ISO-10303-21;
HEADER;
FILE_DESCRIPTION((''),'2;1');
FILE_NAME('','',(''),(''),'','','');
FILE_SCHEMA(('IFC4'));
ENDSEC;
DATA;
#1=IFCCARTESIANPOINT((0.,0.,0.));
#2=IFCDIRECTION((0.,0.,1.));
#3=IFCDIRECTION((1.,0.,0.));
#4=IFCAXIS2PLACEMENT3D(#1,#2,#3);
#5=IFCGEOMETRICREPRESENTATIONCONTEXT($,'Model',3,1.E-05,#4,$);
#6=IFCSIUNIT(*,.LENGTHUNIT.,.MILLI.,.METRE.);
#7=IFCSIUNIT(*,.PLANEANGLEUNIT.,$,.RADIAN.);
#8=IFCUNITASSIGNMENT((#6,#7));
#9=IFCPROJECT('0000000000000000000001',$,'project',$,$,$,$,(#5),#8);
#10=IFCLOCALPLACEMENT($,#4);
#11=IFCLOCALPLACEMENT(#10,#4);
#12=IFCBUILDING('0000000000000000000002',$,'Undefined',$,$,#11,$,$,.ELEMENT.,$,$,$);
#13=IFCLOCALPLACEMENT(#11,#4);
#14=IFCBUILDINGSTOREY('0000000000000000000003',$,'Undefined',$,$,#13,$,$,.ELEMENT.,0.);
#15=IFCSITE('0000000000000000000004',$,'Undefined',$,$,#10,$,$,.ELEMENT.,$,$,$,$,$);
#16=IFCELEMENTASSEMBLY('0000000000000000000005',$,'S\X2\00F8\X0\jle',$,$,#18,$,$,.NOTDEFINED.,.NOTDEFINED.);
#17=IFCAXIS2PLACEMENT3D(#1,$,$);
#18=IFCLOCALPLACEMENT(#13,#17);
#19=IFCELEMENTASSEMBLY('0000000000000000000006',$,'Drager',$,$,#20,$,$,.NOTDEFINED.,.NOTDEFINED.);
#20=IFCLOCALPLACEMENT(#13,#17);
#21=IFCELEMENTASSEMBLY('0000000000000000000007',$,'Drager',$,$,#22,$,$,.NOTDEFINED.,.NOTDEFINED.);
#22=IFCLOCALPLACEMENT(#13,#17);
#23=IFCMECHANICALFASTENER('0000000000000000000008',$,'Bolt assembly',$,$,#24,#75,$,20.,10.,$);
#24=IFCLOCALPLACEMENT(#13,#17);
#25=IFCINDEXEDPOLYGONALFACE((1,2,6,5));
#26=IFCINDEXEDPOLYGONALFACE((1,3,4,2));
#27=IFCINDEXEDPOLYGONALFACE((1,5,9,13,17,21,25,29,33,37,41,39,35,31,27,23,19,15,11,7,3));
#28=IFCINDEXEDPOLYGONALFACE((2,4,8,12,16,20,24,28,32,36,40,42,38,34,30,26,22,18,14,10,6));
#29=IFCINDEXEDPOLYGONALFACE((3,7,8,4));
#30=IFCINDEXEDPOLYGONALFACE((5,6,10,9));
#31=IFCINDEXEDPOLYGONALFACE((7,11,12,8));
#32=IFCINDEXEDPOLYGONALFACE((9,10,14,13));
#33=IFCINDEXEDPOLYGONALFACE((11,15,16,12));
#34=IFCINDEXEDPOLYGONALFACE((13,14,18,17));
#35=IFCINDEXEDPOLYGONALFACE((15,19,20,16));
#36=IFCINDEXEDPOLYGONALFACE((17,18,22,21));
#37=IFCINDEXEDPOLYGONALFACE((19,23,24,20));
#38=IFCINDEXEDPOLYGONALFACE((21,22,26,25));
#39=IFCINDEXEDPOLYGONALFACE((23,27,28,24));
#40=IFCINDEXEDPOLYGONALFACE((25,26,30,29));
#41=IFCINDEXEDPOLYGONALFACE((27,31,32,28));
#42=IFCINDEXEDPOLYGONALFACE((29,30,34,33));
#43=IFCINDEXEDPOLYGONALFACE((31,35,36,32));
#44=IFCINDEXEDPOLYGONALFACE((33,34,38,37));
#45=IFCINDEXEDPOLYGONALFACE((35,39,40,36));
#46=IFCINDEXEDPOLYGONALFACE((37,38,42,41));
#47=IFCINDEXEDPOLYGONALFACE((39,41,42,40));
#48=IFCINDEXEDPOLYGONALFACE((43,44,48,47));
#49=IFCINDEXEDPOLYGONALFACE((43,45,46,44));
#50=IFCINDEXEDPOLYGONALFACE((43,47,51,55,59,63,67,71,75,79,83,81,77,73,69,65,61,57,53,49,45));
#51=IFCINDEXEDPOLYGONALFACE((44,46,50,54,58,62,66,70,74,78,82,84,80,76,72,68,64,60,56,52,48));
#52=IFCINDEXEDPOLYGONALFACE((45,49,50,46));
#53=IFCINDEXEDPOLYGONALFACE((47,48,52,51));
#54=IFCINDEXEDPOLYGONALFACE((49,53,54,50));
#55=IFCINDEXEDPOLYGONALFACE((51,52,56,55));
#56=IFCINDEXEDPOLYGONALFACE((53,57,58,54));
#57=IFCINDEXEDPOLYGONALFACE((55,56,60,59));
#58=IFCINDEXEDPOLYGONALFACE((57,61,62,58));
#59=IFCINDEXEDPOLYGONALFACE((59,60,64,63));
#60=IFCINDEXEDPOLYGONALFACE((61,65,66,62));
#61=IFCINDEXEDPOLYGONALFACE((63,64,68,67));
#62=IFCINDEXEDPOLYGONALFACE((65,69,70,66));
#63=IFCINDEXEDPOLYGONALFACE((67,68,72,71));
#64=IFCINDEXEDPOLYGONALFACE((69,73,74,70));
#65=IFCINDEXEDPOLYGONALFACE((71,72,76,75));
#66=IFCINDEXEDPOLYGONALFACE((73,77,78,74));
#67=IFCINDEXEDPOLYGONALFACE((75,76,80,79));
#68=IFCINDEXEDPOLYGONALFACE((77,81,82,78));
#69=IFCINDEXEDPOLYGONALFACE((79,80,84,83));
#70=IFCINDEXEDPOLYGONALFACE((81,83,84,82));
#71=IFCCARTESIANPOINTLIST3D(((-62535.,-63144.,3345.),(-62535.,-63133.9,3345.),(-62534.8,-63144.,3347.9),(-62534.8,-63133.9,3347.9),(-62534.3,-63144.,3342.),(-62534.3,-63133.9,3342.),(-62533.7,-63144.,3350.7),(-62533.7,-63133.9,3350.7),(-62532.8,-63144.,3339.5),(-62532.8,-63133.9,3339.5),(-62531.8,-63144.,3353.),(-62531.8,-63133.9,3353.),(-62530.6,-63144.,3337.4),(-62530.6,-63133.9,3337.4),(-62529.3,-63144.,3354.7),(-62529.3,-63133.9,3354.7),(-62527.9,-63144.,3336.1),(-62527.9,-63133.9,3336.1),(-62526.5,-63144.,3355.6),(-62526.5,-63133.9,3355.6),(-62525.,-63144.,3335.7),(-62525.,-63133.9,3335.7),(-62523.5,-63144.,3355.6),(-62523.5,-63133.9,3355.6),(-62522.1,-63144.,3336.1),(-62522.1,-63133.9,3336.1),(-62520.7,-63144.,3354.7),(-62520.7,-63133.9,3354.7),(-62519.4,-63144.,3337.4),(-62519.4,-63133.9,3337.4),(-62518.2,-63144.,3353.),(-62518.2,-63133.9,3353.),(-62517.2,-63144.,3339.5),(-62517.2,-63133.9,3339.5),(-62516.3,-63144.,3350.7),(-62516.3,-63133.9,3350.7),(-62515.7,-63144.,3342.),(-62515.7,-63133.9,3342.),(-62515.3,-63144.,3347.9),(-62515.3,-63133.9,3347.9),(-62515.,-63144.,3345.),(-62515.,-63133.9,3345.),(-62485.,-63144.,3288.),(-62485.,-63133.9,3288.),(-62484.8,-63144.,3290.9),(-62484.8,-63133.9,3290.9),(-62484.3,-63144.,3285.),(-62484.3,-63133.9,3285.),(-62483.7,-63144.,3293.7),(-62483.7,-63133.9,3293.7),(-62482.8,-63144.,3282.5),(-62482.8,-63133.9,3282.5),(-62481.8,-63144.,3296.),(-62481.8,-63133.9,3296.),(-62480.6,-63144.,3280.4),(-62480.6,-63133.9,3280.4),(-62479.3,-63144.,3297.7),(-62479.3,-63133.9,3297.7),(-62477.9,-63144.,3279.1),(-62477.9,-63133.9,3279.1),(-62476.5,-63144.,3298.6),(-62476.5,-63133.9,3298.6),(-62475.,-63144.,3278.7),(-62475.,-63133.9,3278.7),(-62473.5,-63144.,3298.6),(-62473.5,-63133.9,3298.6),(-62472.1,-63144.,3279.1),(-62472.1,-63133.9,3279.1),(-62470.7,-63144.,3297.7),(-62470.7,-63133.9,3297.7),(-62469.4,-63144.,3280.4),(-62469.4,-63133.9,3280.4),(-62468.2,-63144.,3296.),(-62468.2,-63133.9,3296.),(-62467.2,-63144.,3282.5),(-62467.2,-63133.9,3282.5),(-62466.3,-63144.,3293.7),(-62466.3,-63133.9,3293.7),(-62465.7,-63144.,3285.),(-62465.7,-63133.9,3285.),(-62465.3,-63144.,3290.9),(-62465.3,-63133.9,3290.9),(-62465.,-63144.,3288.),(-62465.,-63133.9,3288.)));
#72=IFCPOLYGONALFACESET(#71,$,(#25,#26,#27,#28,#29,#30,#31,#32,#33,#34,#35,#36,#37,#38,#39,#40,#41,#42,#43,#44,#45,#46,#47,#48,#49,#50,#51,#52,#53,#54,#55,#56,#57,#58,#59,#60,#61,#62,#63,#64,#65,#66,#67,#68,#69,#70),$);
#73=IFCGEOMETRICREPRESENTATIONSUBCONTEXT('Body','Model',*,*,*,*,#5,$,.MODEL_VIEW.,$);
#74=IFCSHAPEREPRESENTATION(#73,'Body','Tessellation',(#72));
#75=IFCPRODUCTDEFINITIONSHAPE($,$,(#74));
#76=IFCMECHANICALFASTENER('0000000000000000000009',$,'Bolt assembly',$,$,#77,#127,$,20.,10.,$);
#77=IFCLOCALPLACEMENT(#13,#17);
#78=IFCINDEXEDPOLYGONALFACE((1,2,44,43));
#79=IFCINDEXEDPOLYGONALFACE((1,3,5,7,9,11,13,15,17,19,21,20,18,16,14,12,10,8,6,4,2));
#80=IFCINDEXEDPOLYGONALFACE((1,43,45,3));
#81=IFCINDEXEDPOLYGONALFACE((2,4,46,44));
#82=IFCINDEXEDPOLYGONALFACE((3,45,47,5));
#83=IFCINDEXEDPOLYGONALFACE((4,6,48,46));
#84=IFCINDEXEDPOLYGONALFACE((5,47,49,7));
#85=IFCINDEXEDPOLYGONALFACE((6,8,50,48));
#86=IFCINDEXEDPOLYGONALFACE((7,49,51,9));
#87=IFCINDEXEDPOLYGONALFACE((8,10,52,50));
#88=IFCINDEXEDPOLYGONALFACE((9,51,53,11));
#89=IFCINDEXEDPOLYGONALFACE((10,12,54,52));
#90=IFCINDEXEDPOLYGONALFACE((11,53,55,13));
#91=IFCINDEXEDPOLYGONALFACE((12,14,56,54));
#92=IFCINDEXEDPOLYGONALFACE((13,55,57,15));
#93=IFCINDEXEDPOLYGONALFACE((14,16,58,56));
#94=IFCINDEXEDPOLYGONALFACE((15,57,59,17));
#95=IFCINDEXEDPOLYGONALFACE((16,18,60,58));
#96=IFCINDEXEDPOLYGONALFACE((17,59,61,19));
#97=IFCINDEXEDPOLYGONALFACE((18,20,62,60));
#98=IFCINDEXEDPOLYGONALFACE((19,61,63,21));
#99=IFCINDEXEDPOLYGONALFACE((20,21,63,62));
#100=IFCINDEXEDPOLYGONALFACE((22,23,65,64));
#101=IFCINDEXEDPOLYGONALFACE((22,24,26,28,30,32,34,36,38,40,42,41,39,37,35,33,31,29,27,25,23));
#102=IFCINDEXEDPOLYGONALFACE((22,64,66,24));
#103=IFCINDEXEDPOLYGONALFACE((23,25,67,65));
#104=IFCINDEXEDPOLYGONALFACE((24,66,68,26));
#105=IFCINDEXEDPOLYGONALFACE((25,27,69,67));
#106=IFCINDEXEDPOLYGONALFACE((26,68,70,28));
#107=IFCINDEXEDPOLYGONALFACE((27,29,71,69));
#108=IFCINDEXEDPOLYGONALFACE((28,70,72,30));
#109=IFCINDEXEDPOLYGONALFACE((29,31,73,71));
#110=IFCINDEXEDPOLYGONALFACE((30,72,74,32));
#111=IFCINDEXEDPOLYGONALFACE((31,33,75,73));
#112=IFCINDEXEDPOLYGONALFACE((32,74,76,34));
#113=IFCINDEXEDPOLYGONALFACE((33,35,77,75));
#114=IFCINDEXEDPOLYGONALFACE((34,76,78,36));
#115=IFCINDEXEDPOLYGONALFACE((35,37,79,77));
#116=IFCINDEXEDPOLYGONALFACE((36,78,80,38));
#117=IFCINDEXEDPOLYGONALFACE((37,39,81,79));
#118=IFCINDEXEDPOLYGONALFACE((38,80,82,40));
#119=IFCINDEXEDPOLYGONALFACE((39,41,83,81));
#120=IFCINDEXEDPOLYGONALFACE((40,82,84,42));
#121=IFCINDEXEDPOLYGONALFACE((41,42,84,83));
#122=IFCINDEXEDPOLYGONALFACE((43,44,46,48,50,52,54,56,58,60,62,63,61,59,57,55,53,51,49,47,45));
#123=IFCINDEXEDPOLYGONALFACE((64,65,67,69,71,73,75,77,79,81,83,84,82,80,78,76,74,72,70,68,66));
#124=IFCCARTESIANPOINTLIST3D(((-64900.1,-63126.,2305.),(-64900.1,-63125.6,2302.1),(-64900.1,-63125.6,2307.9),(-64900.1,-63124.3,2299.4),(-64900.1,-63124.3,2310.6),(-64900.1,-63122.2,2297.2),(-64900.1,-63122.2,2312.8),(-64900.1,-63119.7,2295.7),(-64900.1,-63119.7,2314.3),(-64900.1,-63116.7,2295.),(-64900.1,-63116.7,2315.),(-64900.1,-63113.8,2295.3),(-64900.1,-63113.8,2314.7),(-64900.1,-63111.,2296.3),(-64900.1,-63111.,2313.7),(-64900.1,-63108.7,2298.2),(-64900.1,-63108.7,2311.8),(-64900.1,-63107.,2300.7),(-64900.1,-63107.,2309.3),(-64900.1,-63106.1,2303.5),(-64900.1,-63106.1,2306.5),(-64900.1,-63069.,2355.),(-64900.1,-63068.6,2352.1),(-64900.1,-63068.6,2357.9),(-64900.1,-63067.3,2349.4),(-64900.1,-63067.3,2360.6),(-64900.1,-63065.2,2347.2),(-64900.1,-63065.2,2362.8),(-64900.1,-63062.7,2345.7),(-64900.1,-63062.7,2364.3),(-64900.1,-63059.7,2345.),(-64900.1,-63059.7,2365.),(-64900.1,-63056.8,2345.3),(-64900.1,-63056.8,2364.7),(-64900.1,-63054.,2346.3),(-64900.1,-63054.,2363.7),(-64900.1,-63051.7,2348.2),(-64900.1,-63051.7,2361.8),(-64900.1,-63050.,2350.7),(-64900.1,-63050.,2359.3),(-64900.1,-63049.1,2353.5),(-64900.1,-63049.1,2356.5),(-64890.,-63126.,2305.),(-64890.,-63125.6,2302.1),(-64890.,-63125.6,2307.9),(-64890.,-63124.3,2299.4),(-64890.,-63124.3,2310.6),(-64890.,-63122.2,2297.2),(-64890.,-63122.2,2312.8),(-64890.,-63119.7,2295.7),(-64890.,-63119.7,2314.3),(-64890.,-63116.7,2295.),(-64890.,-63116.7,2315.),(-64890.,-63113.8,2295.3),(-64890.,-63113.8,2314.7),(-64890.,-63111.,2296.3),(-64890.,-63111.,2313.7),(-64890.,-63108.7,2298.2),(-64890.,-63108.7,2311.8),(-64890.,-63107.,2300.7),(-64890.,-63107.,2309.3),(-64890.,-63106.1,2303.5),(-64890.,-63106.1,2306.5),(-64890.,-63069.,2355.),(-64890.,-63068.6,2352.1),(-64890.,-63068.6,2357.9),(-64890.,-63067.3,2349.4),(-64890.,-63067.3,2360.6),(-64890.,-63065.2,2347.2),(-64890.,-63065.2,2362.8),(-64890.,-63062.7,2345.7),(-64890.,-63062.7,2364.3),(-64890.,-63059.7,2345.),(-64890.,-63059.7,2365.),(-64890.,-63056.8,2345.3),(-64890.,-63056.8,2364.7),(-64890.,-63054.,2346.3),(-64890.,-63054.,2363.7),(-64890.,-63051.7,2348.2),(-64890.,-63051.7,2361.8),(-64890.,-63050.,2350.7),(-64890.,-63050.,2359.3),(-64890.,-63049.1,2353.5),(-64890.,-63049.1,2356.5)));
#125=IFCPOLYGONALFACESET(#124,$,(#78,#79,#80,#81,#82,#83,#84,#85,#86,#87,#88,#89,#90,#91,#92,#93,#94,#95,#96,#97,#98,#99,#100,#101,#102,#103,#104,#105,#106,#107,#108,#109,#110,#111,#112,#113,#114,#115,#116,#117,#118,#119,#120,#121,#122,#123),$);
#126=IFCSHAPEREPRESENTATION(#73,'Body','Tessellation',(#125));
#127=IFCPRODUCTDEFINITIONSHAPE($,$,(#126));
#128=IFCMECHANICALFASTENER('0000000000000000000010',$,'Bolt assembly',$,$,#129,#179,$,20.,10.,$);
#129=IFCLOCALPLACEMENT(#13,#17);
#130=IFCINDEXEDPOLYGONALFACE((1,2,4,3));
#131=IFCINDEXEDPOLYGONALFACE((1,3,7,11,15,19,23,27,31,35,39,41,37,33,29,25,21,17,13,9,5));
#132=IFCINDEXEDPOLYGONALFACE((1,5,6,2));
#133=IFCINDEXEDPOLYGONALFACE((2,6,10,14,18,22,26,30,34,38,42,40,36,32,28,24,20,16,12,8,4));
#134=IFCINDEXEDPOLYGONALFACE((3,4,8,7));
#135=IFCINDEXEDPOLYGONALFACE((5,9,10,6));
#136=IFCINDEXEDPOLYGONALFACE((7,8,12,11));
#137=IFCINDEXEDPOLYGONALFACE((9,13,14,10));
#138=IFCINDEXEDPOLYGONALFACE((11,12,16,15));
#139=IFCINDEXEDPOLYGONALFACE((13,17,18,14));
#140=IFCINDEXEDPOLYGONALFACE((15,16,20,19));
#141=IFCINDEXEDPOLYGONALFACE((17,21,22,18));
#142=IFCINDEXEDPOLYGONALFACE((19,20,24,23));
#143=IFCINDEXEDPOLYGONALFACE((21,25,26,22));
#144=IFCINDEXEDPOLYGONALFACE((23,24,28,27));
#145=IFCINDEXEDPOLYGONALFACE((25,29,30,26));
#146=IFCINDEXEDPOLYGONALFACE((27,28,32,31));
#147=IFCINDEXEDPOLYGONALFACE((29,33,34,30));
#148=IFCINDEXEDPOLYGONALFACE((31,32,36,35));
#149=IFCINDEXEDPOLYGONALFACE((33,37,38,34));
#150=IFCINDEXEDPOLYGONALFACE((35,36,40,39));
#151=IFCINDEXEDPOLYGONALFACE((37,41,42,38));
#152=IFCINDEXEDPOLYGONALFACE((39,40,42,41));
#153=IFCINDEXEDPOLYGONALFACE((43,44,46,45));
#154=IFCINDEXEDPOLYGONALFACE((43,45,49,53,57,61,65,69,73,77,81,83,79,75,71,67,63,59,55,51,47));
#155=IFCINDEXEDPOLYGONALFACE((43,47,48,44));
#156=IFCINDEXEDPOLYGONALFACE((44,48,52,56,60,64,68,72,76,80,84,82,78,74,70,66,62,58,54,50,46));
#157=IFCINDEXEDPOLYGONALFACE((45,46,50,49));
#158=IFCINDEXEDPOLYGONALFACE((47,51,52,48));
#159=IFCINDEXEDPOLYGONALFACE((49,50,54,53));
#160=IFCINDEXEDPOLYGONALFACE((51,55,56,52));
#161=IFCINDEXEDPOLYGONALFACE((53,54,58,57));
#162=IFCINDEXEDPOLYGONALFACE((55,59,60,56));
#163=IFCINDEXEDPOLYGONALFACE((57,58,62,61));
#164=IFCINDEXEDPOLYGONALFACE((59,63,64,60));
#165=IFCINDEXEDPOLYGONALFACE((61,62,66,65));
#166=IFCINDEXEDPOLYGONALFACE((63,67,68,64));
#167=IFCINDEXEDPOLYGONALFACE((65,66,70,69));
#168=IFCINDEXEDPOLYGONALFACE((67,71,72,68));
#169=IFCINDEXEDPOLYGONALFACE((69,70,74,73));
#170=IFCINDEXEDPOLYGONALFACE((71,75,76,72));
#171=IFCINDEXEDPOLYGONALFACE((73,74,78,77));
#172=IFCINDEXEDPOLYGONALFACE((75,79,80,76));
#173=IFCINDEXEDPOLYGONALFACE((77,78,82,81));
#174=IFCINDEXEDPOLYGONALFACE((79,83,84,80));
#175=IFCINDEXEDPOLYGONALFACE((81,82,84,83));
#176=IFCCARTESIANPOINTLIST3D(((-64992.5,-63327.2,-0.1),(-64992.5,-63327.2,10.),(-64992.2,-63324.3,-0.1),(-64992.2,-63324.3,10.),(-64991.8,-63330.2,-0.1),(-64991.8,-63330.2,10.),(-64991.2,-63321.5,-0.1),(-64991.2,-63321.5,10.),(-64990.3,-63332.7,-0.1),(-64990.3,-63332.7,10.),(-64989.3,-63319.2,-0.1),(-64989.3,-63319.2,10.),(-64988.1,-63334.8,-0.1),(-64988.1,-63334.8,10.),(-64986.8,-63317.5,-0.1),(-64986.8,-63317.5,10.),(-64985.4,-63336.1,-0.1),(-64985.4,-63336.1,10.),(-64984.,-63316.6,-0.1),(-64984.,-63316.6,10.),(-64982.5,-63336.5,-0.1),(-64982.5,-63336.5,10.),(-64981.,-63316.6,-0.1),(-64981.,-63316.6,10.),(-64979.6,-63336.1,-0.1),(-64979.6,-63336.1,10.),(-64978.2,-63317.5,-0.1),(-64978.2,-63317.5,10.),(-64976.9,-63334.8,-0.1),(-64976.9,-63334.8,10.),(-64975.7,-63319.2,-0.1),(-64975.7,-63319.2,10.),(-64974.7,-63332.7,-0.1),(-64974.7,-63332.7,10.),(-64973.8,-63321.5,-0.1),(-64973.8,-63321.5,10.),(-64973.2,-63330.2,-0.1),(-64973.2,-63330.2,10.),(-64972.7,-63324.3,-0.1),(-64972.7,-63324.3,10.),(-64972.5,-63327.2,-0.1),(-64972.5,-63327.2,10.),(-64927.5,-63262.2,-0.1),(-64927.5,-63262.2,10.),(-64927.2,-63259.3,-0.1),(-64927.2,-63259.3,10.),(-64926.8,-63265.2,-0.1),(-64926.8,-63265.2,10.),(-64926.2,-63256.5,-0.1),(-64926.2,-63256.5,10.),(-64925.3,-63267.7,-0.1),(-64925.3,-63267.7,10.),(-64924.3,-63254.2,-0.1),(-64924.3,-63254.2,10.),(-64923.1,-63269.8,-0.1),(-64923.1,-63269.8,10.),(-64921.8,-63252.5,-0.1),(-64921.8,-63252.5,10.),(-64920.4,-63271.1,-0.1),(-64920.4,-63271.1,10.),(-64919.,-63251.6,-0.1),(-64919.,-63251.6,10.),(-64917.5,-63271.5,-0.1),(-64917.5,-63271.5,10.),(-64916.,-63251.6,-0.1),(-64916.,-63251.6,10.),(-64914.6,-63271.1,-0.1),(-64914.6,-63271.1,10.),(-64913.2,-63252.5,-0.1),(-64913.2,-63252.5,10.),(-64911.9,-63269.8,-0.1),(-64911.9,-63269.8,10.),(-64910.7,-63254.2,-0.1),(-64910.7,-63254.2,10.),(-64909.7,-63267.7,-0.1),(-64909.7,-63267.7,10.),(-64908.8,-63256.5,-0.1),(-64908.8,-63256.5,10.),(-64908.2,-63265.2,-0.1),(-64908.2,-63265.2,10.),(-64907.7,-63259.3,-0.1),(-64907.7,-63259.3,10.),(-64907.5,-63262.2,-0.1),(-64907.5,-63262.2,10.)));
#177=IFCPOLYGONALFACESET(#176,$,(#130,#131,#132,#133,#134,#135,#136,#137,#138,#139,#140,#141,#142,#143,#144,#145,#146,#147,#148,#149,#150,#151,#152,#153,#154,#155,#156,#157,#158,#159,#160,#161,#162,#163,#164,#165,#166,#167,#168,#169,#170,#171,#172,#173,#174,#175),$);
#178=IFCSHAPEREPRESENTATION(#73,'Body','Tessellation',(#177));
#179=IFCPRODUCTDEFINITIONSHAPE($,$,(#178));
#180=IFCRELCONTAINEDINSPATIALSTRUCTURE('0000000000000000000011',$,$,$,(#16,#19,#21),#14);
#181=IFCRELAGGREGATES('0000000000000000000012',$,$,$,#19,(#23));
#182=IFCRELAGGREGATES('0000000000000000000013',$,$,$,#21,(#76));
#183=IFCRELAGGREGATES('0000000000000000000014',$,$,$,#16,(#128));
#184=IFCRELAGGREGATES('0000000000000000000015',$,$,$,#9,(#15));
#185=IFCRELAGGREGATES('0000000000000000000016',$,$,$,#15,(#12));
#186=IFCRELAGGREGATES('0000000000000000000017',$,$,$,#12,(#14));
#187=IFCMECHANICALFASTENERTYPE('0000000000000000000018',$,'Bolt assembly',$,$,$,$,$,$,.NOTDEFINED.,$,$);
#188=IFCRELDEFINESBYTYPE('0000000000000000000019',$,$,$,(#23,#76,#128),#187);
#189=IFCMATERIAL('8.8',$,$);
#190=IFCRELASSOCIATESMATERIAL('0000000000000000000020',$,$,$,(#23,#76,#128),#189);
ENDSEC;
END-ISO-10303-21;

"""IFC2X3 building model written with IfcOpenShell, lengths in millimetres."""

from ifc_helpers import new_model, si_unit, frame, origin_with_axes, origin_2d_with_axis, place, context, subcontext, project, spatial, circle, extrude, source, transform, mapped, material, type_object, element, aggregate, save


model = new_model("IFC2X3")

# Units and contexts
model_context = context("Model", 3, precision=1e-05, world=origin_with_axes())
body_context = subcontext(model_context, "Body", "Model", "MODEL_VIEW")
ifc_project = project(units=[si_unit("LENGTHUNIT", "METRE", prefix="MILLI"), si_unit("PLANEANGLEUNIT", "RADIAN")], contexts=[model_context])

# Site, building, storey
site_placement = place(None, origin_with_axes())
site = spatial("IfcSite", under=ifc_project, at=site_placement, Name="Undefined", CompositionType="ELEMENT")
building_placement = place(site_placement, origin_with_axes())
building = spatial("IfcBuilding", under=site, at=building_placement, Name="Undefined", CompositionType="ELEMENT")
storey_placement = place(building_placement, origin_with_axes())
storey = spatial("IfcBuildingStorey", under=building, at=storey_placement, Name="Undefined", CompositionType="ELEMENT", Elevation=0.0)

# Element assembly
assembly_1_placement = place(storey_placement, origin_with_axes())
assembly_1 = element("IfcElementAssembly", 1, at=assembly_1_placement, inside=storey, Name="Søjle", AssemblyPlace="NOTDEFINED", PredefinedType="NOTDEFINED")

# Element assembly
assembly_2_placement = place(storey_placement, origin_with_axes())
assembly_2 = element("IfcElementAssembly", 2, at=assembly_2_placement, inside=storey, Name="Drager", AssemblyPlace="NOTDEFINED", PredefinedType="NOTDEFINED")

# Element assembly
assembly_3_placement = place(storey_placement, origin_with_axes())
assembly_3 = element("IfcElementAssembly", 3, at=assembly_3_placement, inside=storey, Name="Drager", AssemblyPlace="NOTDEFINED", PredefinedType="NOTDEFINED")

# Mechanical fasteners
ifc_material_1 = material(Name="8.8")
mechanical_fastener_type = type_object("IfcMechanicalFastenerType", Name="Bolt assembly")
shared_shape_1 = source(origin_with_axes(), body_context, "Body", "SweptSolid", [
    extrude(circle(Radius=10.0, at=origin_2d_with_axis()), frame((0.0, 0.0, 0.0), z_axis=(0.0, 1.0, 0.0), x_axis=(1.0, 0.0, 0.0)), (0.0, 0.0, 1.0), 10.1),
])
mechanical_fastener_1_placement = place(assembly_2_placement, frame((-62500.0, -63144.0, 3345.7), z_axis=(1.0, 0.0, 0.0), x_axis=(0.0, 0.0, -1.0)))
mechanical_fastener_1 = element("IfcMechanicalFastener", 4, at=mechanical_fastener_1_placement, type_object=mechanical_fastener_type, material=ifc_material_1, Name="Bolt assembly", NominalDiameter=20.0, NominalLength=10.0, context=body_context, shape_type="MappedRepresentation", body=[
    mapped(shared_shape_1, transform((0.0, 0.0, -25.0))),
    mapped(shared_shape_1, transform((57.0, 0.0, 25.0))),
])
mechanical_fastener_2_placement = place(assembly_3_placement, frame((-64890.0, -63059.0, 2330.0), z_axis=(0.0, 0.0, -1.0), x_axis=(0.0, -1.0, 0.0)))
mechanical_fastener_2 = element("IfcMechanicalFastener", 5, at=mechanical_fastener_2_placement, type_object=mechanical_fastener_type, material=ifc_material_1, Name="Bolt assembly", NominalDiameter=20.0, NominalLength=10.0, context=body_context, shape_type="MappedRepresentation", body=[
    mapped(shared_shape_1, transform((0.0, 0.0, -25.0))),
    mapped(shared_shape_1, transform((57.0, 0.0, 25.0))),
])
mechanical_fastener_3_placement = place(assembly_1_placement, frame((-64950.0, -63261.5, 10.0), z_axis=(1.0, 0.0, 0.0), x_axis=(0.0, -1.0, 0.0)))
mechanical_fastener_3 = element("IfcMechanicalFastener", 6, at=mechanical_fastener_3_placement, type_object=mechanical_fastener_type, material=ifc_material_1, Name="Bolt assembly", NominalDiameter=20.0, NominalLength=10.0, context=body_context, shape_type="MappedRepresentation", body=[
    mapped(shared_shape_1, transform((65.0, 0.0, -32.5))),
    mapped(shared_shape_1, transform((0.0, 0.0, 32.5))),
])
aggregate(assembly_2, [mechanical_fastener_1])
aggregate(assembly_3, [mechanical_fastener_2])
aggregate(assembly_1, [mechanical_fastener_3])

save(model, "model.ifc")
